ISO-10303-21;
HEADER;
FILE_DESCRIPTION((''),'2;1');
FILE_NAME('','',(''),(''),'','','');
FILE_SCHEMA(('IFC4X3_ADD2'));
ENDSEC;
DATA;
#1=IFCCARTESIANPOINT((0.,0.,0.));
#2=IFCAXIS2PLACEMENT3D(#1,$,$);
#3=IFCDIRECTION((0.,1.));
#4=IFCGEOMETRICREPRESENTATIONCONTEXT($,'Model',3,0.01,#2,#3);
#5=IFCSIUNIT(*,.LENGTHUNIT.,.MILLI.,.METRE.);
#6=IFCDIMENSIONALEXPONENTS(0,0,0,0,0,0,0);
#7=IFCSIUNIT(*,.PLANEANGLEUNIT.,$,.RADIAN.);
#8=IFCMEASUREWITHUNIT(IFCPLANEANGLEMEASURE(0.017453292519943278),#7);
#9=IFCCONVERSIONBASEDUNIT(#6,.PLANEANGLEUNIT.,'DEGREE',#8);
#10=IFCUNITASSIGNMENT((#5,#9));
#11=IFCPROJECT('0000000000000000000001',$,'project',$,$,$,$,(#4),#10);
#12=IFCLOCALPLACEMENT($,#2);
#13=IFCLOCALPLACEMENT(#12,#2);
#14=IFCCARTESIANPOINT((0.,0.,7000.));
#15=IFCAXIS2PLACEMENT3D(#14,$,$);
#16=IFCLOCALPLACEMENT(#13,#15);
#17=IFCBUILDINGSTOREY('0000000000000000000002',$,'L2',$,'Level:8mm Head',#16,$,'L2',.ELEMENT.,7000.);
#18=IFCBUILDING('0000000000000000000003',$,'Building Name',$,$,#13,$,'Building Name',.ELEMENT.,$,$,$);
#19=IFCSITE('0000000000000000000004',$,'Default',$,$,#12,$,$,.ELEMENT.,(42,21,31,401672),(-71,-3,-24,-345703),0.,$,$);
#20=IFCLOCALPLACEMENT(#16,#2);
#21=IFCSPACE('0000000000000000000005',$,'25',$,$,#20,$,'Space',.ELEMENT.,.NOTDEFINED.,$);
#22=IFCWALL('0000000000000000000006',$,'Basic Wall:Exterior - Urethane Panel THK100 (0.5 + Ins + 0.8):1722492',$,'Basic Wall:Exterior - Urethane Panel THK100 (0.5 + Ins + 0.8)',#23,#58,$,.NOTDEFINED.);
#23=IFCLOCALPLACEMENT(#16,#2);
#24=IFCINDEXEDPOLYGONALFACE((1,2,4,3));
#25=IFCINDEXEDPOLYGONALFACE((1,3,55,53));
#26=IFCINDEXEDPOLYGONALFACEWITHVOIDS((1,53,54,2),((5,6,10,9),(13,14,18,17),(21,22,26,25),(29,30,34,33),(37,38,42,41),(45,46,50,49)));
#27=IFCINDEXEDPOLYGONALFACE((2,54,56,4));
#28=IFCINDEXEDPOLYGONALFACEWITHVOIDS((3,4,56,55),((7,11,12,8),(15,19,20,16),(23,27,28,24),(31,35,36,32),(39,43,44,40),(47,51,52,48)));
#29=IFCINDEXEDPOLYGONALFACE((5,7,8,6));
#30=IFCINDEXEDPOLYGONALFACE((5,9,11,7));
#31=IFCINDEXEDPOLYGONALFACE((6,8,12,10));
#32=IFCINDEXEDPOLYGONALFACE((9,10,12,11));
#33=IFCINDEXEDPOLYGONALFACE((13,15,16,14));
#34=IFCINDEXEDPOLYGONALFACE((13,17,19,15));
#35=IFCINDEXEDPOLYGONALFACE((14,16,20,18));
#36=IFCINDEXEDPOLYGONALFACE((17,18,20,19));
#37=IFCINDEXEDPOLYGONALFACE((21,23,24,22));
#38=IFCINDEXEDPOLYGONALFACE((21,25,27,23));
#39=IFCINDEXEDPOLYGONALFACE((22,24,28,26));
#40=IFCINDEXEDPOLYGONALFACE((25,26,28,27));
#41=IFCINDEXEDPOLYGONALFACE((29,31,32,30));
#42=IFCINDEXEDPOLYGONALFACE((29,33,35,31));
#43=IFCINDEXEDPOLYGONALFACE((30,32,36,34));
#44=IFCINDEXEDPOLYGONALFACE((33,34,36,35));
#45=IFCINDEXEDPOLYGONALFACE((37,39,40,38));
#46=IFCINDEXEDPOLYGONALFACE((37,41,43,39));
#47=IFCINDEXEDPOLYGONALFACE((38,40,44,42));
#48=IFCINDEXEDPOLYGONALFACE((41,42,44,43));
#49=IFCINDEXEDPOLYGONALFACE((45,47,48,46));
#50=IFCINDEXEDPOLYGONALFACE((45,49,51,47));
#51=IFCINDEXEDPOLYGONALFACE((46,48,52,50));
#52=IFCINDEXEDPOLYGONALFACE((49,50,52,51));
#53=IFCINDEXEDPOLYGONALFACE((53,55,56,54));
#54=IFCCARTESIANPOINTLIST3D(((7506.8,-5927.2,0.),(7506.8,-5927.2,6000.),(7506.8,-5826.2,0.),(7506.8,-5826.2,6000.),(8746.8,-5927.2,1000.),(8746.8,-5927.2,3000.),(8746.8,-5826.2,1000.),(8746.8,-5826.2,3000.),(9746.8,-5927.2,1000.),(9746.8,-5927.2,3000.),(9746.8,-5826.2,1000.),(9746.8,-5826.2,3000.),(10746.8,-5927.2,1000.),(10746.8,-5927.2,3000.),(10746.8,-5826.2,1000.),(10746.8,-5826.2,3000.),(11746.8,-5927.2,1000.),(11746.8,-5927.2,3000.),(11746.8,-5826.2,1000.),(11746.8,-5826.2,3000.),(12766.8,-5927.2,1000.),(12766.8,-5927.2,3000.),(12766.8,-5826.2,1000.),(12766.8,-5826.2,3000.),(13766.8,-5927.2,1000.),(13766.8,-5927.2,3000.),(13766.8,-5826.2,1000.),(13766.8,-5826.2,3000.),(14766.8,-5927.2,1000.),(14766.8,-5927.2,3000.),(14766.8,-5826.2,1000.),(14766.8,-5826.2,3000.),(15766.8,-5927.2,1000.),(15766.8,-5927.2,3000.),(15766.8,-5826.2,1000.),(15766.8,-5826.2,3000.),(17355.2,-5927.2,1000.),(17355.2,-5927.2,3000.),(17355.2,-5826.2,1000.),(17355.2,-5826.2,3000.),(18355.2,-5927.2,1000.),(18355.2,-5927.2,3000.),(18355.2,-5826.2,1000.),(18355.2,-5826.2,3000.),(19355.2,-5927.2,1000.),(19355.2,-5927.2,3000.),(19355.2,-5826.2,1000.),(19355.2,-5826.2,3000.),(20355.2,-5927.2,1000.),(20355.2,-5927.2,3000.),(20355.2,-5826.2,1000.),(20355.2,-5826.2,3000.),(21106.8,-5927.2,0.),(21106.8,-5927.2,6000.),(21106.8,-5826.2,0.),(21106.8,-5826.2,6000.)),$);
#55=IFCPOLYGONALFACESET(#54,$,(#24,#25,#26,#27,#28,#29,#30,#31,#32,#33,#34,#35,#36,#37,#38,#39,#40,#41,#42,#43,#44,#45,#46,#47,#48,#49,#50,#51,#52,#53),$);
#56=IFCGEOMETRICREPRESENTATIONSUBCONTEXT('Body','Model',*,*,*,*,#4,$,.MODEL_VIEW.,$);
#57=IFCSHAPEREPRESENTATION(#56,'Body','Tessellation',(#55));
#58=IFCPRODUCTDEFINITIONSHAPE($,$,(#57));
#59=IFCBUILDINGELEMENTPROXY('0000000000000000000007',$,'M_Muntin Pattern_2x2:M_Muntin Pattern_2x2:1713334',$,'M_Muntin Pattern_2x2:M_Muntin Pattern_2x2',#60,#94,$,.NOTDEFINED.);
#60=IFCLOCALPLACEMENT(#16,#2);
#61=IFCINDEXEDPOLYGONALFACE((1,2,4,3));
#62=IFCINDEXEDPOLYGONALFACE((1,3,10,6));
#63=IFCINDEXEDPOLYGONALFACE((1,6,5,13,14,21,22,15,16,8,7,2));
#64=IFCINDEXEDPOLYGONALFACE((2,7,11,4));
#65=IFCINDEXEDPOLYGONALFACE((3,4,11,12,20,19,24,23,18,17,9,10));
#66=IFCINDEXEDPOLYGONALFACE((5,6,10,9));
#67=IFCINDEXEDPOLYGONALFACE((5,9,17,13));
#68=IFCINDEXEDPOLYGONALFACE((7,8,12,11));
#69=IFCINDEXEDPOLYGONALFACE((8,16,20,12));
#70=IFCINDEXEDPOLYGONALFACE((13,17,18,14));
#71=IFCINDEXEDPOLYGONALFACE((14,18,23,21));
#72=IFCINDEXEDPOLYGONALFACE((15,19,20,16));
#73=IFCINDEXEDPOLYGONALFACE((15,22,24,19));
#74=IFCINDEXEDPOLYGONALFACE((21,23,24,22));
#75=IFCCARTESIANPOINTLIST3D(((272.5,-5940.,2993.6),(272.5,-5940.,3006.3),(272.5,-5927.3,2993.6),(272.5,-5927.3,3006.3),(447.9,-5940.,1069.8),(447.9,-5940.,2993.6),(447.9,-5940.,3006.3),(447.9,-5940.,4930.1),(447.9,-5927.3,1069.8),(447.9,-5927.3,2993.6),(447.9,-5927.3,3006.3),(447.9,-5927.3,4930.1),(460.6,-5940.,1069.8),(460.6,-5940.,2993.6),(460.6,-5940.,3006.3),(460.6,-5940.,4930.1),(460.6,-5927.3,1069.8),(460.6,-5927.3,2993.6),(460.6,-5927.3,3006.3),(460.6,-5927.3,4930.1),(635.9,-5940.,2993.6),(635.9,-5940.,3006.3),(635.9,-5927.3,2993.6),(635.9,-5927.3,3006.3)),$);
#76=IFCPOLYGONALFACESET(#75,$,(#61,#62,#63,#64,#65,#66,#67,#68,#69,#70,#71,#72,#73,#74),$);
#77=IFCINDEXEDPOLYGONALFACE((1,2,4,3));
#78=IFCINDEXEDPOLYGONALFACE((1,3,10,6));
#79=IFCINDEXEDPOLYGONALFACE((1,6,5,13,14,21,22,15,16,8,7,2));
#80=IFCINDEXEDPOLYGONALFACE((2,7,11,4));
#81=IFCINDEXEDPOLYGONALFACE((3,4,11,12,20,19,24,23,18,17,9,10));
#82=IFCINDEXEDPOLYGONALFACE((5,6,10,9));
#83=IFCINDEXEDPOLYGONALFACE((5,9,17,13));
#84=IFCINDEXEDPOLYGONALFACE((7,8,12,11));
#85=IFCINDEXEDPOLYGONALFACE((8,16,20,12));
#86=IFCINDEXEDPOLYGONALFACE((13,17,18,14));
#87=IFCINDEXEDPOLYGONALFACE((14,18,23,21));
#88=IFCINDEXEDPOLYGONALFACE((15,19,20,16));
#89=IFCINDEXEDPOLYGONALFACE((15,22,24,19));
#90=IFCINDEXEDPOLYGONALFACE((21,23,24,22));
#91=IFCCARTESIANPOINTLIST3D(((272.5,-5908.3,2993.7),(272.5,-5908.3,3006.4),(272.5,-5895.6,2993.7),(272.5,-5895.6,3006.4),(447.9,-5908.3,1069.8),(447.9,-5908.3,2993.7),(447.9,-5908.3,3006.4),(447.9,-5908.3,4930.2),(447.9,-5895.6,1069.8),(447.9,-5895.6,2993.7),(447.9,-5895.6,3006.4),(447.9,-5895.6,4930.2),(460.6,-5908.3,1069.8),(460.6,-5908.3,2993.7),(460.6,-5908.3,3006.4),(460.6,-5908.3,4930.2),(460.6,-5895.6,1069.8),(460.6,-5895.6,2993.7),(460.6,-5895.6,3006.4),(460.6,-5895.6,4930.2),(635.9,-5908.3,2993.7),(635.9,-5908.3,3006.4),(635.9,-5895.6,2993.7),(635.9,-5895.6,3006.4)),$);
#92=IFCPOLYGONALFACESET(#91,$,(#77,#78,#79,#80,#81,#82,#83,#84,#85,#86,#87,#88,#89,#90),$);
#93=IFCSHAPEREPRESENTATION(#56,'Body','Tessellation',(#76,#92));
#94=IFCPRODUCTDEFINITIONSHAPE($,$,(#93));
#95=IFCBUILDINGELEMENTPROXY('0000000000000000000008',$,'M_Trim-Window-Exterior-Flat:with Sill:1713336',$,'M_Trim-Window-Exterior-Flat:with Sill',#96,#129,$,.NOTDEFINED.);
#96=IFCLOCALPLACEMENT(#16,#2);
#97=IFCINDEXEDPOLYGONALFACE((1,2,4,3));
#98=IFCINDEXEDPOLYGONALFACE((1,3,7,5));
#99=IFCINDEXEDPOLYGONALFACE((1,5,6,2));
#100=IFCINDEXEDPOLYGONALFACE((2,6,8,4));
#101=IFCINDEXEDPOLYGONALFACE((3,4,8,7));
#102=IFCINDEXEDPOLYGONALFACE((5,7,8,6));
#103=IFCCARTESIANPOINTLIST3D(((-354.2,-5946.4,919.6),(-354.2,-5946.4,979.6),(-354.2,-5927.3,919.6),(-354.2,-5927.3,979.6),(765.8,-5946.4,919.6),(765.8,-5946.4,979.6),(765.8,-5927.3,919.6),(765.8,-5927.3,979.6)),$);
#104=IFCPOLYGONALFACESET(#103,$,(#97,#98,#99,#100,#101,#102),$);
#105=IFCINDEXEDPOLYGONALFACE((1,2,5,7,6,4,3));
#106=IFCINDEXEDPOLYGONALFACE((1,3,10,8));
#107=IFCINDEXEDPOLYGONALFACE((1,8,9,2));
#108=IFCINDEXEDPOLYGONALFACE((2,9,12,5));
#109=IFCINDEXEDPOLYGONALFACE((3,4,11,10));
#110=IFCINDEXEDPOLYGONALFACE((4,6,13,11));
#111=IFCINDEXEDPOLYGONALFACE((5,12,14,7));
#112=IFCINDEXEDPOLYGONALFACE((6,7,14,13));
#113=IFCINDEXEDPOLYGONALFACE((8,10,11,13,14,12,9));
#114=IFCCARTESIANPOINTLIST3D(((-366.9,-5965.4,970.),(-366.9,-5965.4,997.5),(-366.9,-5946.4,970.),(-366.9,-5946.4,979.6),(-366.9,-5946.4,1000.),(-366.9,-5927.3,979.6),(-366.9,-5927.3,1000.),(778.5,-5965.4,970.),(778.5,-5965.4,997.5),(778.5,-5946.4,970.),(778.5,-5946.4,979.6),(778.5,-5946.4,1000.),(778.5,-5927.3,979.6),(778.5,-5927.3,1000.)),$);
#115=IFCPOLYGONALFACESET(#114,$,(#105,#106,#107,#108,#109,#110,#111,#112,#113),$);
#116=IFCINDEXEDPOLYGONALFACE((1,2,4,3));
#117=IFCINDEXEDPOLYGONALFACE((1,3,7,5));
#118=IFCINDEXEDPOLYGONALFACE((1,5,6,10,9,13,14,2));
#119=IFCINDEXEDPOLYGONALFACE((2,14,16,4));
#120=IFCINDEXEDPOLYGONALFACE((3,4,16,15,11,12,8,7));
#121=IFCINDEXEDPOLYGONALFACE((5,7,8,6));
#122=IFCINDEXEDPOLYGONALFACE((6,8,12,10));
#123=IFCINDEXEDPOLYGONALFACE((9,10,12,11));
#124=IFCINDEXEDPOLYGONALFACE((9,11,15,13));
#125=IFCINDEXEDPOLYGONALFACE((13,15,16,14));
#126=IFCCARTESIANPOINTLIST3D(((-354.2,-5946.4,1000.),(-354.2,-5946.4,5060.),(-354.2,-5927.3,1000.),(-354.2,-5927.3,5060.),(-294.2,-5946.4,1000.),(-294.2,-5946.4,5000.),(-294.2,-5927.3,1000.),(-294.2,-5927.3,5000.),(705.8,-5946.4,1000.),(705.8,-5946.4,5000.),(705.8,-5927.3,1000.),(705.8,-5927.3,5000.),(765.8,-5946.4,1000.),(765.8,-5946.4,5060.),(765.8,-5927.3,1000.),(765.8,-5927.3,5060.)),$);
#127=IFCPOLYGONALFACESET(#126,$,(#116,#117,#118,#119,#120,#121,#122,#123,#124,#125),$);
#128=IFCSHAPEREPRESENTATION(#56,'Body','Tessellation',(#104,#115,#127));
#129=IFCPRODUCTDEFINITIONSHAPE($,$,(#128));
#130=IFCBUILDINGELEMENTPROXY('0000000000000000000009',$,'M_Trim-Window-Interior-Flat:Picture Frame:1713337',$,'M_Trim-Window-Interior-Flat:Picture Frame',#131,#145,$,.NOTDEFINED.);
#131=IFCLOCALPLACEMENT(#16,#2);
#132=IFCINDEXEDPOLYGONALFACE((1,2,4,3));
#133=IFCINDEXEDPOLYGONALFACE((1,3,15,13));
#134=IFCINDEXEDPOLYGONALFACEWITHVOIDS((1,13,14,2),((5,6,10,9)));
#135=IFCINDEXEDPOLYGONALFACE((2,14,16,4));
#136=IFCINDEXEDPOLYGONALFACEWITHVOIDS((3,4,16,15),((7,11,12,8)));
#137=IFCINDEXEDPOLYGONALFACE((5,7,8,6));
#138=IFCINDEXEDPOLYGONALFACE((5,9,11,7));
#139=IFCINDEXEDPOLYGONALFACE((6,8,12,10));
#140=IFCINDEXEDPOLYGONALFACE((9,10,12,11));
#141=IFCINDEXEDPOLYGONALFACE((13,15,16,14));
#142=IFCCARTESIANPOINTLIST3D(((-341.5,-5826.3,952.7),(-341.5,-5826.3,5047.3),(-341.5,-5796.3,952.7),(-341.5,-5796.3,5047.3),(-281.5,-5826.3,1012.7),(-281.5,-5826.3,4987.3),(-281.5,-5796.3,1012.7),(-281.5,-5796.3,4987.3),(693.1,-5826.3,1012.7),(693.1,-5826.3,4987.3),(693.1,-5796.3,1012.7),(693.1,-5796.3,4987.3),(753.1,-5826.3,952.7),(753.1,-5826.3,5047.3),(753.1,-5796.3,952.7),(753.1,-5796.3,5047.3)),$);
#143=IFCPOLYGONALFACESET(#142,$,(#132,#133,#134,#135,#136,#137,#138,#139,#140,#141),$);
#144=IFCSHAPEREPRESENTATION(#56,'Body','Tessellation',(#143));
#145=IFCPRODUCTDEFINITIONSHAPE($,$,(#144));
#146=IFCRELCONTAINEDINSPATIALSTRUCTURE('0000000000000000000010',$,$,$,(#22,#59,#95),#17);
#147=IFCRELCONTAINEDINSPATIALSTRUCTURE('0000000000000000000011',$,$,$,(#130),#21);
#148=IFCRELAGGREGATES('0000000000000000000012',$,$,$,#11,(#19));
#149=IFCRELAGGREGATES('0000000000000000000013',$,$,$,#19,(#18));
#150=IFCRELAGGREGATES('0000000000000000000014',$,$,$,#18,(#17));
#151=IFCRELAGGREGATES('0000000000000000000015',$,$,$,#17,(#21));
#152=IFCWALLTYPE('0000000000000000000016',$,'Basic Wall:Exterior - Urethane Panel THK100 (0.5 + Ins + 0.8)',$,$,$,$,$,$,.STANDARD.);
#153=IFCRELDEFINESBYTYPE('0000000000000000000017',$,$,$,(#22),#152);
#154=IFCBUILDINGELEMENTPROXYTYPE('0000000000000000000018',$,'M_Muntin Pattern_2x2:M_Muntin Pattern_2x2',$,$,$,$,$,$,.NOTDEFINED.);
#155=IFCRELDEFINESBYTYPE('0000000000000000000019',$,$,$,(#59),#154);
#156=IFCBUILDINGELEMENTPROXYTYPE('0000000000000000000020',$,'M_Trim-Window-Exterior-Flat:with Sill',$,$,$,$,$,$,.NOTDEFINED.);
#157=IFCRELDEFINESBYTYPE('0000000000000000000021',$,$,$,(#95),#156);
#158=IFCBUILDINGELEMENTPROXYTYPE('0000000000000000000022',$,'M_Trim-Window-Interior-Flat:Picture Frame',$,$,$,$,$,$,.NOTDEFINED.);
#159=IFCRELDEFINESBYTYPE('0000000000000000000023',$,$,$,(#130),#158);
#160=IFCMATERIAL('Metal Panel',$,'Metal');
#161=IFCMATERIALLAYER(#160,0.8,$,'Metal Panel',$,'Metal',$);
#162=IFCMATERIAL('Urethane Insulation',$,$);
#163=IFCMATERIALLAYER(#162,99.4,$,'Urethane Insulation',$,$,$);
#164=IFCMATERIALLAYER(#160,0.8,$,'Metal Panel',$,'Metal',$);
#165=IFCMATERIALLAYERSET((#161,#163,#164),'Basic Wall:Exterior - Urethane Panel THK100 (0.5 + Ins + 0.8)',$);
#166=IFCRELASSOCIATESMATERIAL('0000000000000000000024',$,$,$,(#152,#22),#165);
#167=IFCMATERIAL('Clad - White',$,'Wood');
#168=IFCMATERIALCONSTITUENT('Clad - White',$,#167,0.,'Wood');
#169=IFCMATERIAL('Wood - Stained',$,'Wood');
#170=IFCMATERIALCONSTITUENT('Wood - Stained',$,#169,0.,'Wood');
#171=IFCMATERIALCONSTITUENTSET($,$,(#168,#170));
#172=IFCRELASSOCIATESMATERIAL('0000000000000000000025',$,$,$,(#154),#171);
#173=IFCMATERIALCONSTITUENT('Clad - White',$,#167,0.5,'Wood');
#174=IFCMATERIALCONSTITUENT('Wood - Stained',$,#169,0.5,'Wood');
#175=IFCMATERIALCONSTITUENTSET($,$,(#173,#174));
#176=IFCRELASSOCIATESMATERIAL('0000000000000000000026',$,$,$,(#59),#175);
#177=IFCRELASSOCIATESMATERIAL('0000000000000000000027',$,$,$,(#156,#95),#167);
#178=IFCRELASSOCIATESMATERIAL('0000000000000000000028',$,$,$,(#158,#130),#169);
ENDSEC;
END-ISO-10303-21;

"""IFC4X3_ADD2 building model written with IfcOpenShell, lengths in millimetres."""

from ifc_helpers import new_model, entity, si_unit, converted_unit, direction, frame, frame_2d, origin, place, context, subcontext, project, spatial, polyline, rectangle, outline, extrude, source, transform, mapped, material, layer, layer_set, constituent, constituent_set, type_object, type_shapes, element, save


model = new_model("IFC4X3_ADD2")

# Units and contexts
model_context = context("Model", 3, precision=0.01, world=origin(), true_north=direction((0.0, 1.0)))
body_context = subcontext(model_context, "Body", "Model", "MODEL_VIEW")
ifc_project = project(units=[si_unit("LENGTHUNIT", "METRE", prefix="MILLI"), converted_unit("PLANEANGLEUNIT", "DEGREE", entity("IfcPlaneAngleMeasure", 0.017453292519943278), si_unit("PLANEANGLEUNIT", "RADIAN"), dimensions=[0, 0, 0, 0, 0, 0, 0])], contexts=[model_context])

# Site, building, storey
site_placement = place(None, origin())
site = spatial("IfcSite", under=ifc_project, at=site_placement, Name="Default", CompositionType="ELEMENT", RefLatitude=(42, 21, 31, 401672), RefLongitude=(-71, -3, -24, -345703), RefElevation=0.0)
building_placement = place(site_placement, origin())
building = spatial("IfcBuilding", under=site, at=building_placement, Name="Building Name", LongName="Building Name", CompositionType="ELEMENT")
storey_placement = place(building_placement, frame((0.0, 0.0, 7000.0)))
storey = spatial("IfcBuildingStorey", under=building, at=storey_placement, Name="L2", ObjectType="Level:8mm Head", LongName="L2", CompositionType="ELEMENT", Elevation=7000.0)

# Shared definitions
ifc_material_1 = material(Name="Metal Panel", Category="Metal")
ifc_layer_1 = layer(ifc_material_1, 0.8, Name="Metal Panel", Category="Metal")
ifc_material_2 = material(Name="Urethane Insulation")
ifc_layer_2 = layer(ifc_material_2, 99.4, Name="Urethane Insulation")
ifc_layer_3 = layer(ifc_material_1, 0.8, Name="Metal Panel", Category="Metal")
ifc_layer_set = layer_set([ifc_layer_1, ifc_layer_2, ifc_layer_3], Name="Basic Wall:Exterior - Urethane Panel THK100 (0.5 + Ins + 0.8)")
wall_type = type_object("IfcWallType", Name="Basic Wall:Exterior - Urethane Panel THK100 (0.5 + Ins + 0.8)", PredefinedType="STANDARD", material=ifc_layer_set)

# Wall, openings
wall_1_placement = place(storey_placement, frame((7506.8, -5876.7, 0.0)))
wall_1 = element("IfcWall", 1, at=wall_1_placement, inside=storey, type_object=wall_type, material=ifc_layer_set, Name="Basic Wall:Exterior - Urethane Panel THK100 (0.5 + Ins + 0.8):1722492", ObjectType="Basic Wall:Exterior - Urethane Panel THK100 (0.5 + Ins + 0.8)", PredefinedType="NOTDEFINED", context=body_context, shape_type="SweptSolid", body=[
    extrude(rectangle(XDim=13600.0, YDim=101.0, at=frame_2d((6800.0, 0.0), x_axis=(-1.0, 0.0))), origin(), (0.0, 0.0, 1.0), 6000.0),
])
opening_1_placement = place(wall_1_placement, frame((2240.0, 50.5, 1000.0)))
element("IfcOpeningElement", 2, at=opening_1_placement, cuts=wall_1, PredefinedType="OPENING", context=body_context, shape_type="SweptSolid", body=[
    extrude(rectangle(XDim=2000.0, YDim=1000.0, at=frame_2d((1000.0, 500.0), x_axis=(-1.0, 0.0))), frame((0.0, 0.0, 0.0), z_axis=(0.0, -1.0, 0.0), x_axis=(0.0, 0.0, 1.0)), (0.0, 0.0, 1.0), 101.0),
])
opening_2_placement = place(wall_1_placement, frame((4240.0, 50.5, 1000.0)))
element("IfcOpeningElement", 3, at=opening_2_placement, cuts=wall_1, PredefinedType="OPENING", context=body_context, shape_type="SweptSolid", body=[
    extrude(rectangle(XDim=2000.0, YDim=1000.0, at=frame_2d((1000.0, 500.0), x_axis=(-1.0, 0.0))), frame((0.0, 0.0, 0.0), z_axis=(0.0, -1.0, 0.0), x_axis=(0.0, 0.0, 1.0)), (0.0, 0.0, 1.0), 101.0),
])
opening_3_placement = place(wall_1_placement, frame((6260.0, 50.5, 1000.0)))
element("IfcOpeningElement", 4, at=opening_3_placement, cuts=wall_1, PredefinedType="OPENING", context=body_context, shape_type="SweptSolid", body=[
    extrude(rectangle(XDim=2000.0, YDim=1000.0, at=frame_2d((1000.0, 500.0), x_axis=(-1.0, 0.0))), frame((0.0, 0.0, 0.0), z_axis=(0.0, -1.0, 0.0), x_axis=(0.0, 0.0, 1.0)), (0.0, 0.0, 1.0), 101.0),
])
opening_4_placement = place(wall_1_placement, frame((8260.0, 50.5, 1000.0)))
element("IfcOpeningElement", 5, at=opening_4_placement, cuts=wall_1, PredefinedType="OPENING", context=body_context, shape_type="SweptSolid", body=[
    extrude(rectangle(XDim=2000.0, YDim=1000.0, at=frame_2d((1000.0, 500.0), x_axis=(-1.0, 0.0))), frame((0.0, 0.0, 0.0), z_axis=(0.0, -1.0, 0.0), x_axis=(0.0, 0.0, 1.0)), (0.0, 0.0, 1.0), 101.0),
])
opening_5_placement = place(wall_1_placement, frame((10848.4, 50.5, 1000.0)))
element("IfcOpeningElement", 6, at=opening_5_placement, cuts=wall_1, PredefinedType="OPENING", context=body_context, shape_type="SweptSolid", body=[
    extrude(rectangle(XDim=2000.0, YDim=1000.0, at=frame_2d((1000.0, 500.0), x_axis=(-1.0, 0.0))), frame((0.0, 0.0, 0.0), z_axis=(0.0, -1.0, 0.0), x_axis=(0.0, 0.0, 1.0)), (0.0, 0.0, 1.0), 101.0),
])
opening_6_placement = place(wall_1_placement, frame((12848.4, 50.5, 1000.0)))
element("IfcOpeningElement", 7, at=opening_6_placement, cuts=wall_1, PredefinedType="OPENING", context=body_context, shape_type="SweptSolid", body=[
    extrude(rectangle(XDim=2000.0, YDim=1000.0, at=frame_2d((1000.0, 500.0), x_axis=(-1.0, 0.0))), frame((0.0, 0.0, 0.0), z_axis=(0.0, -1.0, 0.0), x_axis=(0.0, 0.0, 1.0)), (0.0, 0.0, 1.0), 101.0),
])

# Building element proxies
ifc_material_3 = material(Name="Clad - White", Category="Wood")
ifc_constituent_1 = constituent(ifc_material_3, Name="Clad - White", Category="Wood", fraction=0.5)
ifc_material_4 = material(Name="Wood - Stained", Category="Wood")
ifc_constituent_2 = constituent(ifc_material_4, Name="Wood - Stained", Category="Wood", fraction=0.5)
ifc_constituent_set_1 = constituent_set(constituents=[ifc_constituent_1, ifc_constituent_2])
ifc_constituent_3 = constituent(ifc_material_3, Name="Clad - White", Category="Wood", fraction=0.0)
ifc_constituent_4 = constituent(ifc_material_4, Name="Wood - Stained", Category="Wood", fraction=0.0)
ifc_constituent_set_2 = constituent_set(constituents=[ifc_constituent_3, ifc_constituent_4])
building_element_proxy_type_1 = type_object("IfcBuildingElementProxyType", Name="M_Muntin Pattern_2x2:M_Muntin Pattern_2x2", PredefinedType="NOTDEFINED", material=ifc_constituent_set_2)
shared_shape_1 = source(origin(), body_context, "Body", "SweptSolid", [
    extrude(outline(polyline([(6.4, -6.4), (1930.1, -6.4), (1930.1, 6.3), (6.4, 6.3), (6.4, 181.7), (-6.3, 181.7), (-6.3, 6.3), (-1930.2, 6.3), (-1930.2, -6.4), (-6.3, -6.4), (-6.3, -181.7), (6.4, -181.7), (6.4, -6.4)])), frame((0.0, 9.5, 1930.1), z_axis=(0.0, 1.0, 0.0), x_axis=(0.0, 0.0, 1.0)), (0.0, 0.0, 1.0), 12.7),
    extrude(outline(polyline([(6.4, -6.4), (1930.2, -6.4), (1930.2, 6.3), (6.4, 6.3), (6.4, 181.7), (-6.3, 181.7), (-6.3, 6.3), (-1930.2, 6.3), (-1930.2, -6.4), (-6.3, -6.4), (-6.3, -181.7), (6.4, -181.7), (6.4, -6.4)])), frame((0.0, -22.2, 1930.2), z_axis=(0.0, 1.0, 0.0), x_axis=(0.0, 0.0, 1.0)), (0.0, 0.0, 1.0), 12.7),
])
type_shapes(building_element_proxy_type_1, [shared_shape_1])
proxy_1_placement = place(storey_placement, frame((454.2, -5917.8, 1069.8), z_axis=(0.0, 0.0, 1.0), x_axis=(-1.0, 0.0, 0.0)))
element("IfcBuildingElementProxy", 8, at=proxy_1_placement, inside=storey, type_object=building_element_proxy_type_1, material=ifc_constituent_set_1, Name="M_Muntin Pattern_2x2:M_Muntin Pattern_2x2:1713334", ObjectType="M_Muntin Pattern_2x2:M_Muntin Pattern_2x2", PredefinedType="NOTDEFINED", context=body_context, shape_type="MappedRepresentation", body=[
    mapped(shared_shape_1, transform((0.0, 0.0, 0.0), scale=1.0)),
])
building_element_proxy_type_2 = type_object("IfcBuildingElementProxyType", Name="M_Trim-Window-Exterior-Flat:with Sill", PredefinedType="NOTDEFINED", material=ifc_material_3)
shared_shape_2 = source(origin(), body_context, "Body", "SweptSolid", [
    extrude(rectangle(XDim=1120.0, YDim=60.0, at=frame_2d((0.0, 0.0), x_axis=(1.0, 0.0))), frame((0.0, -4050.4, 0.0), z_axis=(0.0, 0.0, 1.0), x_axis=(-1.0, 0.0, 0.0)), (0.0, 0.0, 1.0), 19.0),
    extrude(outline(polyline([(-19.0, -15.2), (0.0, -15.2), (0.0, -5.7), (19.0, -5.7), (19.0, 14.8), (0.0, 14.8), (-19.0, 12.3), (-19.0, -15.2)])), frame((-572.7, -4014.8, 19.0), z_axis=(1.0, 0.0, 0.0), x_axis=(0.0, 0.0, -1.0)), (0.0, 0.0, 1.0), 1145.4),
    extrude(outline(polyline([(-2045.0, -560.0), (2015.0, -560.0), (2015.0, -500.0), (-1985.0, -500.0), (-1985.0, 500.0), (2015.0, 500.0), (2015.0, 560.0), (-2045.0, 560.0), (-2045.0, -560.0)])), frame((0.0, -1985.0, 0.0), z_axis=(0.0, 0.0, 1.0), x_axis=(0.0, -1.0, 0.0)), (0.0, 0.0, 1.0), 19.0),
])
type_shapes(building_element_proxy_type_2, [shared_shape_2])
proxy_2_placement = place(storey_placement, frame((205.8, -5927.3, 5000.0), z_axis=(0.0, -1.0, 0.0), x_axis=(1.0, 0.0, 0.0)))
element("IfcBuildingElementProxy", 9, at=proxy_2_placement, inside=storey, type_object=building_element_proxy_type_2, material=ifc_material_3, Name="M_Trim-Window-Exterior-Flat:with Sill:1713336", ObjectType="M_Trim-Window-Exterior-Flat:with Sill", PredefinedType="NOTDEFINED", context=body_context, shape_type="MappedRepresentation", body=[
    mapped(shared_shape_2, transform((0.0, 0.0, 0.0), scale=1.0)),
])

# Shared definitions
space_1_placement = place(storey_placement, origin())
space_1 = spatial("IfcSpace", under=storey, at=space_1_placement, Name="25", LongName="Space", CompositionType="ELEMENT", PredefinedType="NOTDEFINED")

# Building element proxy
building_element_proxy_type_3 = type_object("IfcBuildingElementProxyType", Name="M_Trim-Window-Interior-Flat:Picture Frame", PredefinedType="NOTDEFINED", material=ifc_material_4)
shared_shape_3 = source(origin(), body_context, "Body", "SweptSolid", [
    extrude(outline(polyline([(-547.3, -2047.3), (547.3, -2047.3), (547.3, 2047.3), (-547.3, 2047.3), (-547.3, -2047.3)]), holes=[polyline([(-487.3, -1987.3), (-487.3, 1987.3), (487.3, 1987.3), (487.3, -1987.3), (-487.3, -1987.3)])]), frame((0.0, -2000.0, 0.0), z_axis=(0.0, 0.0, 1.0), x_axis=(-1.0, 0.0, 0.0)), (0.0, 0.0, 1.0), 30.0),
])
type_shapes(building_element_proxy_type_3, [shared_shape_3])
proxy_3_placement = place(space_1_placement, frame((205.8, -5826.3, 5000.0), z_axis=(0.0, 1.0, 0.0), x_axis=(-1.0, 0.0, 0.0)))
element("IfcBuildingElementProxy", 10, at=proxy_3_placement, inside=space_1, type_object=building_element_proxy_type_3, material=ifc_material_4, Name="M_Trim-Window-Interior-Flat:Picture Frame:1713337", ObjectType="M_Trim-Window-Interior-Flat:Picture Frame", PredefinedType="NOTDEFINED", context=body_context, shape_type="MappedRepresentation", body=[
    mapped(shared_shape_3, transform((0.0, 0.0, 0.0), scale=1.0)),
])

save(model, "model.ifc")
